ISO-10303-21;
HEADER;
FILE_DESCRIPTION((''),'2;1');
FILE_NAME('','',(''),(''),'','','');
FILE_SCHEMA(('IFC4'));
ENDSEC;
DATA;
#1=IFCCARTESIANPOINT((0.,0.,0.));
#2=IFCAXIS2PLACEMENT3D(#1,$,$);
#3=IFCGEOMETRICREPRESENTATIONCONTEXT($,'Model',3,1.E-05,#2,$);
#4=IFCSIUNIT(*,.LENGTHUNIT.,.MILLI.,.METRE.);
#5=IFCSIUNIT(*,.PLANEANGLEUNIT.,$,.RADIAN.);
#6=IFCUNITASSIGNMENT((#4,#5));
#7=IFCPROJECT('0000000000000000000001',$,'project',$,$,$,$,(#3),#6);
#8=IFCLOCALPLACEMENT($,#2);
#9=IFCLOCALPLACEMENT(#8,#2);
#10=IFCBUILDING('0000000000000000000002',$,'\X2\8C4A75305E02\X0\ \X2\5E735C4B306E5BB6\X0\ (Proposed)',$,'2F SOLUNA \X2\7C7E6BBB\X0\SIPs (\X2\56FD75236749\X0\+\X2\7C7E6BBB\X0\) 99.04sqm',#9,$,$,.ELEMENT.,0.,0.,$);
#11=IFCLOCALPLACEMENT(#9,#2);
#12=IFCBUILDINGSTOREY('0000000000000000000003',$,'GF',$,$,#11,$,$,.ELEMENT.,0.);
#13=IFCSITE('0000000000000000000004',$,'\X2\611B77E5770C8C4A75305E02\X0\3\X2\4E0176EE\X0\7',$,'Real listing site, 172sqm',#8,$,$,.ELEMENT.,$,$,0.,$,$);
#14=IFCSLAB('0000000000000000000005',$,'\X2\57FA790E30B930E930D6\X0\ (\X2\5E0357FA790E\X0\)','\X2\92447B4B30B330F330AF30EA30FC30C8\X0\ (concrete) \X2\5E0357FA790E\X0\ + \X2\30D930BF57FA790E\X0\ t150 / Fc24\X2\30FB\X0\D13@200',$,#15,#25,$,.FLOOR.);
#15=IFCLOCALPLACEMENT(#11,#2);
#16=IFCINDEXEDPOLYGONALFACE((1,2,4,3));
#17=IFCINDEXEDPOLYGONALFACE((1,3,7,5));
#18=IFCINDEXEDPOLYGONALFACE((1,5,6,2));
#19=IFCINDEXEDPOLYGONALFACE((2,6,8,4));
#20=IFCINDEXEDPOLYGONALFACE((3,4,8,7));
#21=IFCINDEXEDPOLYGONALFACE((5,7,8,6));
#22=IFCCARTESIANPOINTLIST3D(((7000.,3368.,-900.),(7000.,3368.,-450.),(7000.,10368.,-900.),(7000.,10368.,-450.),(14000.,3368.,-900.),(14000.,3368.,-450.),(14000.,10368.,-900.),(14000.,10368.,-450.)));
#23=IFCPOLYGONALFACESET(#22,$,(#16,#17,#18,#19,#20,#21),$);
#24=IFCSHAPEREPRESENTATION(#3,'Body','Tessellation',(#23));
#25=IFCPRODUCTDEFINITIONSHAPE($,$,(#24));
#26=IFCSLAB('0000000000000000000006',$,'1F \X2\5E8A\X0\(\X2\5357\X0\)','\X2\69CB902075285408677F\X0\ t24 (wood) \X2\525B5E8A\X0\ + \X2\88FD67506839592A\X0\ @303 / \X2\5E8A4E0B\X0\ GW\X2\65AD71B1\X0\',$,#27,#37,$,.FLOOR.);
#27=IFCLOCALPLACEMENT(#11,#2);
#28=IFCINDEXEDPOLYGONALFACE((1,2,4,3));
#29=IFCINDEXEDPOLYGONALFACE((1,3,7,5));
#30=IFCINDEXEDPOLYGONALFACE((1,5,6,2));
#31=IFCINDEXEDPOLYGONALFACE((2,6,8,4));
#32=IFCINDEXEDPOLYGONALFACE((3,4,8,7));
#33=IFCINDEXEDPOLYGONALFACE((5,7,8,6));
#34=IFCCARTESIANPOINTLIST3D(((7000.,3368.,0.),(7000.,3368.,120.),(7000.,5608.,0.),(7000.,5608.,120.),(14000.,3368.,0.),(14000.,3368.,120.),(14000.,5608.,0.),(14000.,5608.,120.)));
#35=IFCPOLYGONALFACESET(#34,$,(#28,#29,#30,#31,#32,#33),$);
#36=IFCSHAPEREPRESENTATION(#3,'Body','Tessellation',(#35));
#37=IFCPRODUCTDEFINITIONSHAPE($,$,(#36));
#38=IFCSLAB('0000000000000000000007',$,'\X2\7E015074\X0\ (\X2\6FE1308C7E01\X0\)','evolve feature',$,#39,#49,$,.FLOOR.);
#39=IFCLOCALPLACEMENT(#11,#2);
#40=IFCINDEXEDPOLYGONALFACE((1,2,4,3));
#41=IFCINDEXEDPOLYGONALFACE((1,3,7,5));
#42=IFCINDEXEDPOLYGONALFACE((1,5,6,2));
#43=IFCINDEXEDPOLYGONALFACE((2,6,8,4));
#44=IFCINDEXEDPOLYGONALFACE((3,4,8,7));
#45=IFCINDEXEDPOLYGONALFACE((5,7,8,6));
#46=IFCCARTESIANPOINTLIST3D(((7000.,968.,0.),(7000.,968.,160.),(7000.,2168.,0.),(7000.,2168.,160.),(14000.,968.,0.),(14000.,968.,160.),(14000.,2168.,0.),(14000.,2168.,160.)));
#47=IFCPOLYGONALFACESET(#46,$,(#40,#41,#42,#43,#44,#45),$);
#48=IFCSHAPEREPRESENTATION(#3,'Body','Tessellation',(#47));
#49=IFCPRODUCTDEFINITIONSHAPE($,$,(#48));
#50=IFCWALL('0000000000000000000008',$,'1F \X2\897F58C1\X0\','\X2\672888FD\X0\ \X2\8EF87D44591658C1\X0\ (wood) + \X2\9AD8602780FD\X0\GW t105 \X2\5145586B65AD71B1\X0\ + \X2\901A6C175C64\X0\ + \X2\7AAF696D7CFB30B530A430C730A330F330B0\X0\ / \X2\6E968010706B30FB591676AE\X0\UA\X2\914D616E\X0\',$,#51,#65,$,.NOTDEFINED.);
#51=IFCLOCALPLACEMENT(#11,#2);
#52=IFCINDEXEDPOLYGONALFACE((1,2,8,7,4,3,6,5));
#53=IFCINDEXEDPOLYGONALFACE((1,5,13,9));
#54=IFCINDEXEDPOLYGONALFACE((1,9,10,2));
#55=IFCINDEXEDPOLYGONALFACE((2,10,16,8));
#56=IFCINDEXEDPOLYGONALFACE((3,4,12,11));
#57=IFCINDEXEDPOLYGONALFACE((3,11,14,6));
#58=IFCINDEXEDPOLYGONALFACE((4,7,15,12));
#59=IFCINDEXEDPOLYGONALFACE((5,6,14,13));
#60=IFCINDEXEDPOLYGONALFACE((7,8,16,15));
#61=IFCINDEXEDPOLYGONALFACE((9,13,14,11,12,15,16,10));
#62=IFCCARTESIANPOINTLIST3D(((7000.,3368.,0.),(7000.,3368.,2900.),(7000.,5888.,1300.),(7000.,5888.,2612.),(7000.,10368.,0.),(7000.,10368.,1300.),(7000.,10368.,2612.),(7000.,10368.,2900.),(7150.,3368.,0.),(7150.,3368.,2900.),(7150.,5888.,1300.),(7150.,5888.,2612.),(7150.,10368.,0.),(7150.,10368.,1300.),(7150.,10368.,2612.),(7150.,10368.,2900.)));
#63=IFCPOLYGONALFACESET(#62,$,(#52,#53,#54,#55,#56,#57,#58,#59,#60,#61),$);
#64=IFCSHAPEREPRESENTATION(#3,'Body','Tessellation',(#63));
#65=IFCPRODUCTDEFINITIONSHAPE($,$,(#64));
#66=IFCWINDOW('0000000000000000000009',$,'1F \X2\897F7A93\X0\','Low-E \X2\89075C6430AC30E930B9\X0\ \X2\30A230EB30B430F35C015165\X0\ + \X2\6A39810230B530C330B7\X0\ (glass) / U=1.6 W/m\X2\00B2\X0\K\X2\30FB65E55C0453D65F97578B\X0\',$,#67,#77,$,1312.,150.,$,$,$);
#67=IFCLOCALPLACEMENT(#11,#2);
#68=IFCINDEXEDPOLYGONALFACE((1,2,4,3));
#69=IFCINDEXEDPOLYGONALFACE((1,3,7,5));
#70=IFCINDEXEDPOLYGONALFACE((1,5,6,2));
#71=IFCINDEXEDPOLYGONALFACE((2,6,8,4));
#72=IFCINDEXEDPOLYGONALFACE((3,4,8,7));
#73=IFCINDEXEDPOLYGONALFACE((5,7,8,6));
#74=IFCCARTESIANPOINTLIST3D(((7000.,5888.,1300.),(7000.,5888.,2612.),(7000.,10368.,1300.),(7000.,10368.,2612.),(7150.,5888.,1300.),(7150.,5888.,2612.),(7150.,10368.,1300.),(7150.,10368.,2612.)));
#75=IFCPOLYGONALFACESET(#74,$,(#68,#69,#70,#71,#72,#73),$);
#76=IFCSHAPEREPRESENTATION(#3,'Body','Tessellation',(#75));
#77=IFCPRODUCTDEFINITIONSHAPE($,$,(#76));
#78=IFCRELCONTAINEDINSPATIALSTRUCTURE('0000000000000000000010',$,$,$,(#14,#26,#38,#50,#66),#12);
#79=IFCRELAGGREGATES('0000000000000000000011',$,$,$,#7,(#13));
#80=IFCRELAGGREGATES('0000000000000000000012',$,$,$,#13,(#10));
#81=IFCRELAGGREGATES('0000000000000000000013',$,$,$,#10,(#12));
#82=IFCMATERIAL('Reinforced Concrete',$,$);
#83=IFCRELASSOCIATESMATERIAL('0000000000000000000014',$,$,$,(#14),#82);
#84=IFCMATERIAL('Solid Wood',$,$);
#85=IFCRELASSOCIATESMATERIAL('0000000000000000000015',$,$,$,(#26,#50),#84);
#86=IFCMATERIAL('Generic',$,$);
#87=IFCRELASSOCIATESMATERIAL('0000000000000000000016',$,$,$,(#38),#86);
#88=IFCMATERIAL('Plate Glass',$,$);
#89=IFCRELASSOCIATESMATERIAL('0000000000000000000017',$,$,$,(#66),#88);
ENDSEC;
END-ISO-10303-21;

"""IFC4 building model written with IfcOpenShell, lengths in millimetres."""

from ifc_helpers import new_model, si_unit, frame, frame_2d, origin, place, context, project, spatial, rectangle, extrude, material, element, fill, save


model = new_model("IFC4")

# Units and contexts
model_context = context("Model", 3, precision=1e-05, world=origin())
ifc_project = project(units=[si_unit("LENGTHUNIT", "METRE", prefix="MILLI"), si_unit("PLANEANGLEUNIT", "RADIAN")], contexts=[model_context])

# Site, building, storey
site_placement = place(None, origin())
site = spatial("IfcSite", under=ifc_project, at=site_placement, Name="愛知県豊田市3丁目7", ObjectType="Real listing site, 172sqm", CompositionType="ELEMENT", RefElevation=0.0)
building_placement = place(site_placement, origin())
building = spatial("IfcBuilding", under=site, at=building_placement, Name="豊田市 平屋の家 (Proposed)", ObjectType="2F SOLUNA 籾殻SIPs (国産杉+籾殻) 99.04sqm", CompositionType="ELEMENT", ElevationOfRefHeight=0.0, ElevationOfTerrain=0.0)
storey_placement = place(building_placement, origin())
storey = spatial("IfcBuildingStorey", under=building, at=storey_placement, Name="GF", CompositionType="ELEMENT", Elevation=0.0)

# Slabs
ifc_material_1 = material(Name="Reinforced Concrete")
slab_1_placement = place(storey_placement, frame((3500.0, 1684.0, -450.0)))
element("IfcSlab", 1, at=slab_1_placement, inside=storey, material=ifc_material_1, Name="基礎スラブ (布基礎)", Description="鉄筋コンクリート (concrete) 布基礎 + ベタ基礎 t150 / Fc24・D13@200", PredefinedType="FLOOR", context=model_context, shape_type="SweptSolid", body=[
    extrude(rectangle(XDim=7000.0, YDim=7000.0, at=frame_2d((3500.0, 3500.0))), frame((3500.0, 1684.0, -450.0)), (0.0, 0.0, 1.0), 450.0),
])
ifc_material_2 = material(Name="Solid Wood")
slab_2_placement = place(storey_placement, frame((3500.0, 1684.0, 0.0)))
element("IfcSlab", 2, at=slab_2_placement, inside=storey, material=ifc_material_2, Name="1F 床(南)", Description="構造用合板 t24 (wood) 剛床 + 製材根太 @303 / 床下 GW断熱", PredefinedType="FLOOR", context=model_context, shape_type="SweptSolid", body=[
    extrude(rectangle(XDim=7000.0, YDim=2240.0, at=frame_2d((3500.0, 1120.0))), frame((3500.0, 1684.0, 0.0)), (0.0, 0.0, 1.0), 120.0),
])
ifc_material_3 = material(Name="Generic")
slab_3_placement = place(storey_placement, frame((3500.0, 484.0, 0.0)))
element("IfcSlab", 3, at=slab_3_placement, inside=storey, material=ifc_material_3, Name="縁側 (濡れ縁)", Description="evolve feature", PredefinedType="FLOOR", context=model_context, shape_type="SweptSolid", body=[
    extrude(rectangle(XDim=7000.0, YDim=1200.0, at=frame_2d((3500.0, 600.0))), frame((3500.0, 484.0, 0.0)), (0.0, 0.0, 1.0), 160.0),
])

# Shared definitions
ifc_material_4 = material(Name="Plate Glass")

# Wall, opening, window
wall_1_placement = place(storey_placement, frame((3500.0, 1684.0, 0.0)))
wall_1 = element("IfcWall", 4, at=wall_1_placement, inside=storey, material=ifc_material_2, Name="1F 西壁", Description="木製 軸組外壁 (wood) + 高性能GW t105 充填断熱 + 通気層 + 窯業系サイディング / 準耐火・外皮UA配慮", PredefinedType="NOTDEFINED", context=model_context, shape_type="SweptSolid", body=[
    extrude(rectangle(XDim=150.0, YDim=7000.0, at=frame_2d((75.0, 3500.0))), frame((3500.0, 1684.0, 0.0)), (0.0, 0.0, 1.0), 2900.0),
])
opening_1_placement = place(storey_placement, frame((3500.0, 2944.0, 650.0)))
opening_1 = element("IfcOpeningElement", 5, at=opening_1_placement, cuts=wall_1, PredefinedType="NOTDEFINED", context=model_context, shape_type="SweptSolid", body=[
    extrude(rectangle(XDim=150.0, YDim=4480.0, at=frame_2d((75.0, 2240.0))), frame((3500.0, 2944.0, 650.0)), (0.0, 0.0, 1.0), 1312.0),
])
window_1_placement = place(storey_placement, frame((3500.0, 2944.0, 650.0)))
window_1 = element("IfcWindow", 6, at=window_1_placement, inside=storey, material=ifc_material_4, Name="1F 西窓", Description="Low-E 複層ガラス アルゴン封入 + 樹脂サッシ (glass) / U=1.6 W/m²K・日射取得型", OverallHeight=1312.0, OverallWidth=150.0, context=model_context, shape_type="SweptSolid", body=[
    extrude(rectangle(XDim=150.0, YDim=4480.0, at=frame_2d((75.0, 2240.0))), frame((3500.0, 2944.0, 650.0)), (0.0, 0.0, 1.0), 1312.0),
])
fill(opening_1, window_1)

save(model, "model.ifc")
